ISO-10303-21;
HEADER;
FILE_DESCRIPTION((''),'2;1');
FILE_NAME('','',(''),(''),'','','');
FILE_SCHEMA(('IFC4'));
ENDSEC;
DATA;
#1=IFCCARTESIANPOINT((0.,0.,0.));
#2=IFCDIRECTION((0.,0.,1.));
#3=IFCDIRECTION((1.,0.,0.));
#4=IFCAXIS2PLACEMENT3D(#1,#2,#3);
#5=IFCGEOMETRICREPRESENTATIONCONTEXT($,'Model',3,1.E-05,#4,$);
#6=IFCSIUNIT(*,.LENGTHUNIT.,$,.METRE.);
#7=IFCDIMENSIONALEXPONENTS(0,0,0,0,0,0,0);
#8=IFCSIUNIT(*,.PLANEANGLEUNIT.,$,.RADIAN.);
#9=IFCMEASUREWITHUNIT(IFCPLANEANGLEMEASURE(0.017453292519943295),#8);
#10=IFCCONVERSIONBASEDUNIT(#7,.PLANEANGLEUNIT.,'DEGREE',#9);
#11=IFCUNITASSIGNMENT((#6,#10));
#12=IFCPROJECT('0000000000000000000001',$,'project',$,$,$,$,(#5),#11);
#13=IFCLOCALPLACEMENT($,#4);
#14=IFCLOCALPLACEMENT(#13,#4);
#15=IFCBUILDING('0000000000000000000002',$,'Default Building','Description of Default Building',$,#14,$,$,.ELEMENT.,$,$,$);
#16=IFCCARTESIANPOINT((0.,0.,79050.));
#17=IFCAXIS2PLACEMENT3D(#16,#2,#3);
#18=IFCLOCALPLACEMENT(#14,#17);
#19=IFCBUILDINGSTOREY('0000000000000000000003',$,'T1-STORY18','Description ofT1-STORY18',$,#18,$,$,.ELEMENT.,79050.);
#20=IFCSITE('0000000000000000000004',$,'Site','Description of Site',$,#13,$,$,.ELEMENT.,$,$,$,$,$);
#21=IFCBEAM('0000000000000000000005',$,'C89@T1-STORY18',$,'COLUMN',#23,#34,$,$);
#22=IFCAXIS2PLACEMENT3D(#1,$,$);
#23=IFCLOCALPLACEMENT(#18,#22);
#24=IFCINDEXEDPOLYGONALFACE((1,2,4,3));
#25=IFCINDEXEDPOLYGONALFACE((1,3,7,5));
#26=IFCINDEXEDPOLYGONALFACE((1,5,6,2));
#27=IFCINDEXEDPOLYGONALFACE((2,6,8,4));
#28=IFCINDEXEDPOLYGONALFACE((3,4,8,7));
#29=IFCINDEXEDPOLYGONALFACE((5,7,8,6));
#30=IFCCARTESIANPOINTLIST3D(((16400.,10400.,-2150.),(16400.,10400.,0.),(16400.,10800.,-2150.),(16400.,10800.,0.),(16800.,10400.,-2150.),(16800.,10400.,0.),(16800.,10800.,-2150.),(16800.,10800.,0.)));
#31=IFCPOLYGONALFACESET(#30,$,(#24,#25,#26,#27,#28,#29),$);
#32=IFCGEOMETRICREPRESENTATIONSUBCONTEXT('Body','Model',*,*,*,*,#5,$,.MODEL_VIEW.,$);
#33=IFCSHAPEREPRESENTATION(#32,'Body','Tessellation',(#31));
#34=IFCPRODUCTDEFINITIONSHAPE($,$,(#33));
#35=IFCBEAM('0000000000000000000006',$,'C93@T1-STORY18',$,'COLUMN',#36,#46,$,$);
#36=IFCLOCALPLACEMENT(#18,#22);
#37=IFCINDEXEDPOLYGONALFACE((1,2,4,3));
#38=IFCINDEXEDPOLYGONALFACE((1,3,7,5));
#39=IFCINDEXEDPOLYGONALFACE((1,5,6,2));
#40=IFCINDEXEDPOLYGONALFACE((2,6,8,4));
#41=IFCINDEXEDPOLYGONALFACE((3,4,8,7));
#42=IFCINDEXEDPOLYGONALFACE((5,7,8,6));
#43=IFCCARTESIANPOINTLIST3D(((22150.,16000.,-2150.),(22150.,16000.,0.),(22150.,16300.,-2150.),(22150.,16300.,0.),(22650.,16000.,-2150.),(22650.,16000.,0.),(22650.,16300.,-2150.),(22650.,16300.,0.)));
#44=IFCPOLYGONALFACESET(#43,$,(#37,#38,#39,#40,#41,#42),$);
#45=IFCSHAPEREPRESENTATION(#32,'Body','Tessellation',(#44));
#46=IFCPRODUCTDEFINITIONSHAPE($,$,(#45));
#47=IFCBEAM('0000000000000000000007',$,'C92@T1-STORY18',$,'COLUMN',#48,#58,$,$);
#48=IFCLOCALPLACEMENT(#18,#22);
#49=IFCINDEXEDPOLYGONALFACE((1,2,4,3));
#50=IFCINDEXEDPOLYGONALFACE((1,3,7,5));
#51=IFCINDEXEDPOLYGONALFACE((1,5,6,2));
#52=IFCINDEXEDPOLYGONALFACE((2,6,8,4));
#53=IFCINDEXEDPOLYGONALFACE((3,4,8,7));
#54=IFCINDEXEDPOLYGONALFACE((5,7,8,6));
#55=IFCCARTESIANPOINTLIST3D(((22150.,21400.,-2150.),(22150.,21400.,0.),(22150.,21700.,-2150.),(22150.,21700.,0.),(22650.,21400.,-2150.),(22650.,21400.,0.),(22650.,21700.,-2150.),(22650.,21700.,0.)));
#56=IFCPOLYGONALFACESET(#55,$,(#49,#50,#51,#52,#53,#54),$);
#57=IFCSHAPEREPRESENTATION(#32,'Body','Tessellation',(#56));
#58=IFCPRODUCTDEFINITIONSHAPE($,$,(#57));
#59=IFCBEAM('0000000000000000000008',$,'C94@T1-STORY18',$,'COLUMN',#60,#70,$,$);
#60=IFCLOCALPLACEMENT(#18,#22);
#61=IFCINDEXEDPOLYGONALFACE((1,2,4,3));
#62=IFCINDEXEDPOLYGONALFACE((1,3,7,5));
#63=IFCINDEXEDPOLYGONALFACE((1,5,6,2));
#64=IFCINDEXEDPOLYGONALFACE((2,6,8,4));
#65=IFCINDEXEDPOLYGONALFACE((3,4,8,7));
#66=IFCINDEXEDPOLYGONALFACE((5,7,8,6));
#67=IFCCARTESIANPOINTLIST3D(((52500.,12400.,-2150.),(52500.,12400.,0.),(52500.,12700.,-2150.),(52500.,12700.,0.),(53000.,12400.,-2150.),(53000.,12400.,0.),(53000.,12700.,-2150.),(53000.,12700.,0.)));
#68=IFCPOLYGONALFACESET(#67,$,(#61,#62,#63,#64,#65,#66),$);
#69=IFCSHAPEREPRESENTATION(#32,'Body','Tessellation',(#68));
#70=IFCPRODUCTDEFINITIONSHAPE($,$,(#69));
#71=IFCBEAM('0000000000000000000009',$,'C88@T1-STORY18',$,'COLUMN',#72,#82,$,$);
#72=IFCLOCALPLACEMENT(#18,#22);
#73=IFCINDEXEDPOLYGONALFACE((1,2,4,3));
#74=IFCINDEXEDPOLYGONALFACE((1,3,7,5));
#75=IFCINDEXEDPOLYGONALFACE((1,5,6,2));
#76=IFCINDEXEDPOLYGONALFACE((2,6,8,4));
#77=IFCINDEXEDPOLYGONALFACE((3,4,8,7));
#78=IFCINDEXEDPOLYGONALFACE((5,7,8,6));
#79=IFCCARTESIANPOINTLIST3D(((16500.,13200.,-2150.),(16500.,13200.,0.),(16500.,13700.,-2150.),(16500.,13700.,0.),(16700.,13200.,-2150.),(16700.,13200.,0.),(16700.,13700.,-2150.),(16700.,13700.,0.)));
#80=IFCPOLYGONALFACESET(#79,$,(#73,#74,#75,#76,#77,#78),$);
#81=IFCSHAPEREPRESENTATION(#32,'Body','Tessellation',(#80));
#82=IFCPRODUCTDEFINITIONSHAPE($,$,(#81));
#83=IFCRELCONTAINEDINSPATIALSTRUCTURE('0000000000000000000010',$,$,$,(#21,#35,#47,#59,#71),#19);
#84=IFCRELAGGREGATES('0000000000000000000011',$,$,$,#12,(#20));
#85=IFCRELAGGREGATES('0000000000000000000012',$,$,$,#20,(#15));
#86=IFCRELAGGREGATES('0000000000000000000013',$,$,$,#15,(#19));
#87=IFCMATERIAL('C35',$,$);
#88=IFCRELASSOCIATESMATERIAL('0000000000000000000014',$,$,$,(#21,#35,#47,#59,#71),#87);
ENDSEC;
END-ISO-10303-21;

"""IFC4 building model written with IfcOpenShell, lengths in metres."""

from ifc_helpers import new_model, entity, si_unit, converted_unit, frame, origin_with_axes, place, context, subcontext, project, spatial, rectangle, extrude, material, element, save


model = new_model("IFC4")

# Units and contexts
model_context = context("Model", 3, precision=1e-05, world=origin_with_axes())
body_context = subcontext(model_context, "Body", "Model", "MODEL_VIEW")
ifc_project = project(units=[si_unit("LENGTHUNIT", "METRE"), converted_unit("PLANEANGLEUNIT", "DEGREE", entity("IfcPlaneAngleMeasure", 0.017453292519943295), si_unit("PLANEANGLEUNIT", "RADIAN"), dimensions=[0, 0, 0, 0, 0, 0, 0])], contexts=[model_context])

# Site, building, storey
site_placement = place(None, origin_with_axes())
site = spatial("IfcSite", under=ifc_project, at=site_placement, Name="Site", Description="Description of Site", CompositionType="ELEMENT")
building_placement = place(site_placement, origin_with_axes())
building = spatial("IfcBuilding", under=site, at=building_placement, Name="Default Building", Description="Description of Default Building", CompositionType="ELEMENT")
storey_placement = place(building_placement, frame((0.0, 0.0, 79050.0), z_axis=(0.0, 0.0, 1.0), x_axis=(1.0, 0.0, 0.0)))
storey = spatial("IfcBuildingStorey", under=building, at=storey_placement, Name="T1-STORY18", Description="Description ofT1-STORY18", CompositionType="ELEMENT", Elevation=79050.0)

# Beams
ifc_material_1 = material(Name="C35")
for number, where, z_axis, x_axis, name in (
    (1, (16600.0, 10600.0, -2150.0), (0.0, 0.0, 1.0), (-1.0, 0.0, 0.0), "C89@T1-STORY18"),
):
    element("IfcBeam", number, at=place(storey_placement, frame(where, z_axis=z_axis, x_axis=x_axis)), inside=storey, material=ifc_material_1, Name=name, ObjectType="COLUMN", context=body_context, shape_type="SweptSolid", body=[
        extrude(rectangle(XDim=400.0, YDim=400.0), origin_with_axes(), (0.0, 0.0, 1.0), 2150.0),
    ])
for number, where, z_axis, x_axis, name in (
    (2, (22400.0, 16150.0, -2150.0), (0.0, 0.0, 1.0), (0.0, -1.0, 0.0), "C93@T1-STORY18"),
    (3, (22400.0, 21550.0, -2150.0), (0.0, 0.0, 1.0), (0.0, -1.0, 0.0), "C92@T1-STORY18"),
    (4, (52750.0, 12550.0, -2150.0), (0.0, 0.0, 1.0), (0.0, -1.0, 0.0), "C94@T1-STORY18"),
):
    element("IfcBeam", number, at=place(storey_placement, frame(where, z_axis=z_axis, x_axis=x_axis)), inside=storey, material=ifc_material_1, Name=name, ObjectType="COLUMN", context=body_context, shape_type="SweptSolid", body=[
        extrude(rectangle(XDim=300.0, YDim=500.0), origin_with_axes(), (0.0, 0.0, 1.0), 2150.0),
    ])
beam_1_placement = place(storey_placement, frame((16600.0, 13450.0, -2150.0), z_axis=(0.0, 0.0, 1.0), x_axis=(-1.0, 0.0, 0.0)))
element("IfcBeam", 5, at=beam_1_placement, inside=storey, material=ifc_material_1, Name="C88@T1-STORY18", ObjectType="COLUMN", context=body_context, shape_type="SweptSolid", body=[
    extrude(rectangle(XDim=200.0, YDim=500.0), origin_with_axes(), (0.0, 0.0, 1.0), 2150.0),
])

save(model, "model.ifc")
